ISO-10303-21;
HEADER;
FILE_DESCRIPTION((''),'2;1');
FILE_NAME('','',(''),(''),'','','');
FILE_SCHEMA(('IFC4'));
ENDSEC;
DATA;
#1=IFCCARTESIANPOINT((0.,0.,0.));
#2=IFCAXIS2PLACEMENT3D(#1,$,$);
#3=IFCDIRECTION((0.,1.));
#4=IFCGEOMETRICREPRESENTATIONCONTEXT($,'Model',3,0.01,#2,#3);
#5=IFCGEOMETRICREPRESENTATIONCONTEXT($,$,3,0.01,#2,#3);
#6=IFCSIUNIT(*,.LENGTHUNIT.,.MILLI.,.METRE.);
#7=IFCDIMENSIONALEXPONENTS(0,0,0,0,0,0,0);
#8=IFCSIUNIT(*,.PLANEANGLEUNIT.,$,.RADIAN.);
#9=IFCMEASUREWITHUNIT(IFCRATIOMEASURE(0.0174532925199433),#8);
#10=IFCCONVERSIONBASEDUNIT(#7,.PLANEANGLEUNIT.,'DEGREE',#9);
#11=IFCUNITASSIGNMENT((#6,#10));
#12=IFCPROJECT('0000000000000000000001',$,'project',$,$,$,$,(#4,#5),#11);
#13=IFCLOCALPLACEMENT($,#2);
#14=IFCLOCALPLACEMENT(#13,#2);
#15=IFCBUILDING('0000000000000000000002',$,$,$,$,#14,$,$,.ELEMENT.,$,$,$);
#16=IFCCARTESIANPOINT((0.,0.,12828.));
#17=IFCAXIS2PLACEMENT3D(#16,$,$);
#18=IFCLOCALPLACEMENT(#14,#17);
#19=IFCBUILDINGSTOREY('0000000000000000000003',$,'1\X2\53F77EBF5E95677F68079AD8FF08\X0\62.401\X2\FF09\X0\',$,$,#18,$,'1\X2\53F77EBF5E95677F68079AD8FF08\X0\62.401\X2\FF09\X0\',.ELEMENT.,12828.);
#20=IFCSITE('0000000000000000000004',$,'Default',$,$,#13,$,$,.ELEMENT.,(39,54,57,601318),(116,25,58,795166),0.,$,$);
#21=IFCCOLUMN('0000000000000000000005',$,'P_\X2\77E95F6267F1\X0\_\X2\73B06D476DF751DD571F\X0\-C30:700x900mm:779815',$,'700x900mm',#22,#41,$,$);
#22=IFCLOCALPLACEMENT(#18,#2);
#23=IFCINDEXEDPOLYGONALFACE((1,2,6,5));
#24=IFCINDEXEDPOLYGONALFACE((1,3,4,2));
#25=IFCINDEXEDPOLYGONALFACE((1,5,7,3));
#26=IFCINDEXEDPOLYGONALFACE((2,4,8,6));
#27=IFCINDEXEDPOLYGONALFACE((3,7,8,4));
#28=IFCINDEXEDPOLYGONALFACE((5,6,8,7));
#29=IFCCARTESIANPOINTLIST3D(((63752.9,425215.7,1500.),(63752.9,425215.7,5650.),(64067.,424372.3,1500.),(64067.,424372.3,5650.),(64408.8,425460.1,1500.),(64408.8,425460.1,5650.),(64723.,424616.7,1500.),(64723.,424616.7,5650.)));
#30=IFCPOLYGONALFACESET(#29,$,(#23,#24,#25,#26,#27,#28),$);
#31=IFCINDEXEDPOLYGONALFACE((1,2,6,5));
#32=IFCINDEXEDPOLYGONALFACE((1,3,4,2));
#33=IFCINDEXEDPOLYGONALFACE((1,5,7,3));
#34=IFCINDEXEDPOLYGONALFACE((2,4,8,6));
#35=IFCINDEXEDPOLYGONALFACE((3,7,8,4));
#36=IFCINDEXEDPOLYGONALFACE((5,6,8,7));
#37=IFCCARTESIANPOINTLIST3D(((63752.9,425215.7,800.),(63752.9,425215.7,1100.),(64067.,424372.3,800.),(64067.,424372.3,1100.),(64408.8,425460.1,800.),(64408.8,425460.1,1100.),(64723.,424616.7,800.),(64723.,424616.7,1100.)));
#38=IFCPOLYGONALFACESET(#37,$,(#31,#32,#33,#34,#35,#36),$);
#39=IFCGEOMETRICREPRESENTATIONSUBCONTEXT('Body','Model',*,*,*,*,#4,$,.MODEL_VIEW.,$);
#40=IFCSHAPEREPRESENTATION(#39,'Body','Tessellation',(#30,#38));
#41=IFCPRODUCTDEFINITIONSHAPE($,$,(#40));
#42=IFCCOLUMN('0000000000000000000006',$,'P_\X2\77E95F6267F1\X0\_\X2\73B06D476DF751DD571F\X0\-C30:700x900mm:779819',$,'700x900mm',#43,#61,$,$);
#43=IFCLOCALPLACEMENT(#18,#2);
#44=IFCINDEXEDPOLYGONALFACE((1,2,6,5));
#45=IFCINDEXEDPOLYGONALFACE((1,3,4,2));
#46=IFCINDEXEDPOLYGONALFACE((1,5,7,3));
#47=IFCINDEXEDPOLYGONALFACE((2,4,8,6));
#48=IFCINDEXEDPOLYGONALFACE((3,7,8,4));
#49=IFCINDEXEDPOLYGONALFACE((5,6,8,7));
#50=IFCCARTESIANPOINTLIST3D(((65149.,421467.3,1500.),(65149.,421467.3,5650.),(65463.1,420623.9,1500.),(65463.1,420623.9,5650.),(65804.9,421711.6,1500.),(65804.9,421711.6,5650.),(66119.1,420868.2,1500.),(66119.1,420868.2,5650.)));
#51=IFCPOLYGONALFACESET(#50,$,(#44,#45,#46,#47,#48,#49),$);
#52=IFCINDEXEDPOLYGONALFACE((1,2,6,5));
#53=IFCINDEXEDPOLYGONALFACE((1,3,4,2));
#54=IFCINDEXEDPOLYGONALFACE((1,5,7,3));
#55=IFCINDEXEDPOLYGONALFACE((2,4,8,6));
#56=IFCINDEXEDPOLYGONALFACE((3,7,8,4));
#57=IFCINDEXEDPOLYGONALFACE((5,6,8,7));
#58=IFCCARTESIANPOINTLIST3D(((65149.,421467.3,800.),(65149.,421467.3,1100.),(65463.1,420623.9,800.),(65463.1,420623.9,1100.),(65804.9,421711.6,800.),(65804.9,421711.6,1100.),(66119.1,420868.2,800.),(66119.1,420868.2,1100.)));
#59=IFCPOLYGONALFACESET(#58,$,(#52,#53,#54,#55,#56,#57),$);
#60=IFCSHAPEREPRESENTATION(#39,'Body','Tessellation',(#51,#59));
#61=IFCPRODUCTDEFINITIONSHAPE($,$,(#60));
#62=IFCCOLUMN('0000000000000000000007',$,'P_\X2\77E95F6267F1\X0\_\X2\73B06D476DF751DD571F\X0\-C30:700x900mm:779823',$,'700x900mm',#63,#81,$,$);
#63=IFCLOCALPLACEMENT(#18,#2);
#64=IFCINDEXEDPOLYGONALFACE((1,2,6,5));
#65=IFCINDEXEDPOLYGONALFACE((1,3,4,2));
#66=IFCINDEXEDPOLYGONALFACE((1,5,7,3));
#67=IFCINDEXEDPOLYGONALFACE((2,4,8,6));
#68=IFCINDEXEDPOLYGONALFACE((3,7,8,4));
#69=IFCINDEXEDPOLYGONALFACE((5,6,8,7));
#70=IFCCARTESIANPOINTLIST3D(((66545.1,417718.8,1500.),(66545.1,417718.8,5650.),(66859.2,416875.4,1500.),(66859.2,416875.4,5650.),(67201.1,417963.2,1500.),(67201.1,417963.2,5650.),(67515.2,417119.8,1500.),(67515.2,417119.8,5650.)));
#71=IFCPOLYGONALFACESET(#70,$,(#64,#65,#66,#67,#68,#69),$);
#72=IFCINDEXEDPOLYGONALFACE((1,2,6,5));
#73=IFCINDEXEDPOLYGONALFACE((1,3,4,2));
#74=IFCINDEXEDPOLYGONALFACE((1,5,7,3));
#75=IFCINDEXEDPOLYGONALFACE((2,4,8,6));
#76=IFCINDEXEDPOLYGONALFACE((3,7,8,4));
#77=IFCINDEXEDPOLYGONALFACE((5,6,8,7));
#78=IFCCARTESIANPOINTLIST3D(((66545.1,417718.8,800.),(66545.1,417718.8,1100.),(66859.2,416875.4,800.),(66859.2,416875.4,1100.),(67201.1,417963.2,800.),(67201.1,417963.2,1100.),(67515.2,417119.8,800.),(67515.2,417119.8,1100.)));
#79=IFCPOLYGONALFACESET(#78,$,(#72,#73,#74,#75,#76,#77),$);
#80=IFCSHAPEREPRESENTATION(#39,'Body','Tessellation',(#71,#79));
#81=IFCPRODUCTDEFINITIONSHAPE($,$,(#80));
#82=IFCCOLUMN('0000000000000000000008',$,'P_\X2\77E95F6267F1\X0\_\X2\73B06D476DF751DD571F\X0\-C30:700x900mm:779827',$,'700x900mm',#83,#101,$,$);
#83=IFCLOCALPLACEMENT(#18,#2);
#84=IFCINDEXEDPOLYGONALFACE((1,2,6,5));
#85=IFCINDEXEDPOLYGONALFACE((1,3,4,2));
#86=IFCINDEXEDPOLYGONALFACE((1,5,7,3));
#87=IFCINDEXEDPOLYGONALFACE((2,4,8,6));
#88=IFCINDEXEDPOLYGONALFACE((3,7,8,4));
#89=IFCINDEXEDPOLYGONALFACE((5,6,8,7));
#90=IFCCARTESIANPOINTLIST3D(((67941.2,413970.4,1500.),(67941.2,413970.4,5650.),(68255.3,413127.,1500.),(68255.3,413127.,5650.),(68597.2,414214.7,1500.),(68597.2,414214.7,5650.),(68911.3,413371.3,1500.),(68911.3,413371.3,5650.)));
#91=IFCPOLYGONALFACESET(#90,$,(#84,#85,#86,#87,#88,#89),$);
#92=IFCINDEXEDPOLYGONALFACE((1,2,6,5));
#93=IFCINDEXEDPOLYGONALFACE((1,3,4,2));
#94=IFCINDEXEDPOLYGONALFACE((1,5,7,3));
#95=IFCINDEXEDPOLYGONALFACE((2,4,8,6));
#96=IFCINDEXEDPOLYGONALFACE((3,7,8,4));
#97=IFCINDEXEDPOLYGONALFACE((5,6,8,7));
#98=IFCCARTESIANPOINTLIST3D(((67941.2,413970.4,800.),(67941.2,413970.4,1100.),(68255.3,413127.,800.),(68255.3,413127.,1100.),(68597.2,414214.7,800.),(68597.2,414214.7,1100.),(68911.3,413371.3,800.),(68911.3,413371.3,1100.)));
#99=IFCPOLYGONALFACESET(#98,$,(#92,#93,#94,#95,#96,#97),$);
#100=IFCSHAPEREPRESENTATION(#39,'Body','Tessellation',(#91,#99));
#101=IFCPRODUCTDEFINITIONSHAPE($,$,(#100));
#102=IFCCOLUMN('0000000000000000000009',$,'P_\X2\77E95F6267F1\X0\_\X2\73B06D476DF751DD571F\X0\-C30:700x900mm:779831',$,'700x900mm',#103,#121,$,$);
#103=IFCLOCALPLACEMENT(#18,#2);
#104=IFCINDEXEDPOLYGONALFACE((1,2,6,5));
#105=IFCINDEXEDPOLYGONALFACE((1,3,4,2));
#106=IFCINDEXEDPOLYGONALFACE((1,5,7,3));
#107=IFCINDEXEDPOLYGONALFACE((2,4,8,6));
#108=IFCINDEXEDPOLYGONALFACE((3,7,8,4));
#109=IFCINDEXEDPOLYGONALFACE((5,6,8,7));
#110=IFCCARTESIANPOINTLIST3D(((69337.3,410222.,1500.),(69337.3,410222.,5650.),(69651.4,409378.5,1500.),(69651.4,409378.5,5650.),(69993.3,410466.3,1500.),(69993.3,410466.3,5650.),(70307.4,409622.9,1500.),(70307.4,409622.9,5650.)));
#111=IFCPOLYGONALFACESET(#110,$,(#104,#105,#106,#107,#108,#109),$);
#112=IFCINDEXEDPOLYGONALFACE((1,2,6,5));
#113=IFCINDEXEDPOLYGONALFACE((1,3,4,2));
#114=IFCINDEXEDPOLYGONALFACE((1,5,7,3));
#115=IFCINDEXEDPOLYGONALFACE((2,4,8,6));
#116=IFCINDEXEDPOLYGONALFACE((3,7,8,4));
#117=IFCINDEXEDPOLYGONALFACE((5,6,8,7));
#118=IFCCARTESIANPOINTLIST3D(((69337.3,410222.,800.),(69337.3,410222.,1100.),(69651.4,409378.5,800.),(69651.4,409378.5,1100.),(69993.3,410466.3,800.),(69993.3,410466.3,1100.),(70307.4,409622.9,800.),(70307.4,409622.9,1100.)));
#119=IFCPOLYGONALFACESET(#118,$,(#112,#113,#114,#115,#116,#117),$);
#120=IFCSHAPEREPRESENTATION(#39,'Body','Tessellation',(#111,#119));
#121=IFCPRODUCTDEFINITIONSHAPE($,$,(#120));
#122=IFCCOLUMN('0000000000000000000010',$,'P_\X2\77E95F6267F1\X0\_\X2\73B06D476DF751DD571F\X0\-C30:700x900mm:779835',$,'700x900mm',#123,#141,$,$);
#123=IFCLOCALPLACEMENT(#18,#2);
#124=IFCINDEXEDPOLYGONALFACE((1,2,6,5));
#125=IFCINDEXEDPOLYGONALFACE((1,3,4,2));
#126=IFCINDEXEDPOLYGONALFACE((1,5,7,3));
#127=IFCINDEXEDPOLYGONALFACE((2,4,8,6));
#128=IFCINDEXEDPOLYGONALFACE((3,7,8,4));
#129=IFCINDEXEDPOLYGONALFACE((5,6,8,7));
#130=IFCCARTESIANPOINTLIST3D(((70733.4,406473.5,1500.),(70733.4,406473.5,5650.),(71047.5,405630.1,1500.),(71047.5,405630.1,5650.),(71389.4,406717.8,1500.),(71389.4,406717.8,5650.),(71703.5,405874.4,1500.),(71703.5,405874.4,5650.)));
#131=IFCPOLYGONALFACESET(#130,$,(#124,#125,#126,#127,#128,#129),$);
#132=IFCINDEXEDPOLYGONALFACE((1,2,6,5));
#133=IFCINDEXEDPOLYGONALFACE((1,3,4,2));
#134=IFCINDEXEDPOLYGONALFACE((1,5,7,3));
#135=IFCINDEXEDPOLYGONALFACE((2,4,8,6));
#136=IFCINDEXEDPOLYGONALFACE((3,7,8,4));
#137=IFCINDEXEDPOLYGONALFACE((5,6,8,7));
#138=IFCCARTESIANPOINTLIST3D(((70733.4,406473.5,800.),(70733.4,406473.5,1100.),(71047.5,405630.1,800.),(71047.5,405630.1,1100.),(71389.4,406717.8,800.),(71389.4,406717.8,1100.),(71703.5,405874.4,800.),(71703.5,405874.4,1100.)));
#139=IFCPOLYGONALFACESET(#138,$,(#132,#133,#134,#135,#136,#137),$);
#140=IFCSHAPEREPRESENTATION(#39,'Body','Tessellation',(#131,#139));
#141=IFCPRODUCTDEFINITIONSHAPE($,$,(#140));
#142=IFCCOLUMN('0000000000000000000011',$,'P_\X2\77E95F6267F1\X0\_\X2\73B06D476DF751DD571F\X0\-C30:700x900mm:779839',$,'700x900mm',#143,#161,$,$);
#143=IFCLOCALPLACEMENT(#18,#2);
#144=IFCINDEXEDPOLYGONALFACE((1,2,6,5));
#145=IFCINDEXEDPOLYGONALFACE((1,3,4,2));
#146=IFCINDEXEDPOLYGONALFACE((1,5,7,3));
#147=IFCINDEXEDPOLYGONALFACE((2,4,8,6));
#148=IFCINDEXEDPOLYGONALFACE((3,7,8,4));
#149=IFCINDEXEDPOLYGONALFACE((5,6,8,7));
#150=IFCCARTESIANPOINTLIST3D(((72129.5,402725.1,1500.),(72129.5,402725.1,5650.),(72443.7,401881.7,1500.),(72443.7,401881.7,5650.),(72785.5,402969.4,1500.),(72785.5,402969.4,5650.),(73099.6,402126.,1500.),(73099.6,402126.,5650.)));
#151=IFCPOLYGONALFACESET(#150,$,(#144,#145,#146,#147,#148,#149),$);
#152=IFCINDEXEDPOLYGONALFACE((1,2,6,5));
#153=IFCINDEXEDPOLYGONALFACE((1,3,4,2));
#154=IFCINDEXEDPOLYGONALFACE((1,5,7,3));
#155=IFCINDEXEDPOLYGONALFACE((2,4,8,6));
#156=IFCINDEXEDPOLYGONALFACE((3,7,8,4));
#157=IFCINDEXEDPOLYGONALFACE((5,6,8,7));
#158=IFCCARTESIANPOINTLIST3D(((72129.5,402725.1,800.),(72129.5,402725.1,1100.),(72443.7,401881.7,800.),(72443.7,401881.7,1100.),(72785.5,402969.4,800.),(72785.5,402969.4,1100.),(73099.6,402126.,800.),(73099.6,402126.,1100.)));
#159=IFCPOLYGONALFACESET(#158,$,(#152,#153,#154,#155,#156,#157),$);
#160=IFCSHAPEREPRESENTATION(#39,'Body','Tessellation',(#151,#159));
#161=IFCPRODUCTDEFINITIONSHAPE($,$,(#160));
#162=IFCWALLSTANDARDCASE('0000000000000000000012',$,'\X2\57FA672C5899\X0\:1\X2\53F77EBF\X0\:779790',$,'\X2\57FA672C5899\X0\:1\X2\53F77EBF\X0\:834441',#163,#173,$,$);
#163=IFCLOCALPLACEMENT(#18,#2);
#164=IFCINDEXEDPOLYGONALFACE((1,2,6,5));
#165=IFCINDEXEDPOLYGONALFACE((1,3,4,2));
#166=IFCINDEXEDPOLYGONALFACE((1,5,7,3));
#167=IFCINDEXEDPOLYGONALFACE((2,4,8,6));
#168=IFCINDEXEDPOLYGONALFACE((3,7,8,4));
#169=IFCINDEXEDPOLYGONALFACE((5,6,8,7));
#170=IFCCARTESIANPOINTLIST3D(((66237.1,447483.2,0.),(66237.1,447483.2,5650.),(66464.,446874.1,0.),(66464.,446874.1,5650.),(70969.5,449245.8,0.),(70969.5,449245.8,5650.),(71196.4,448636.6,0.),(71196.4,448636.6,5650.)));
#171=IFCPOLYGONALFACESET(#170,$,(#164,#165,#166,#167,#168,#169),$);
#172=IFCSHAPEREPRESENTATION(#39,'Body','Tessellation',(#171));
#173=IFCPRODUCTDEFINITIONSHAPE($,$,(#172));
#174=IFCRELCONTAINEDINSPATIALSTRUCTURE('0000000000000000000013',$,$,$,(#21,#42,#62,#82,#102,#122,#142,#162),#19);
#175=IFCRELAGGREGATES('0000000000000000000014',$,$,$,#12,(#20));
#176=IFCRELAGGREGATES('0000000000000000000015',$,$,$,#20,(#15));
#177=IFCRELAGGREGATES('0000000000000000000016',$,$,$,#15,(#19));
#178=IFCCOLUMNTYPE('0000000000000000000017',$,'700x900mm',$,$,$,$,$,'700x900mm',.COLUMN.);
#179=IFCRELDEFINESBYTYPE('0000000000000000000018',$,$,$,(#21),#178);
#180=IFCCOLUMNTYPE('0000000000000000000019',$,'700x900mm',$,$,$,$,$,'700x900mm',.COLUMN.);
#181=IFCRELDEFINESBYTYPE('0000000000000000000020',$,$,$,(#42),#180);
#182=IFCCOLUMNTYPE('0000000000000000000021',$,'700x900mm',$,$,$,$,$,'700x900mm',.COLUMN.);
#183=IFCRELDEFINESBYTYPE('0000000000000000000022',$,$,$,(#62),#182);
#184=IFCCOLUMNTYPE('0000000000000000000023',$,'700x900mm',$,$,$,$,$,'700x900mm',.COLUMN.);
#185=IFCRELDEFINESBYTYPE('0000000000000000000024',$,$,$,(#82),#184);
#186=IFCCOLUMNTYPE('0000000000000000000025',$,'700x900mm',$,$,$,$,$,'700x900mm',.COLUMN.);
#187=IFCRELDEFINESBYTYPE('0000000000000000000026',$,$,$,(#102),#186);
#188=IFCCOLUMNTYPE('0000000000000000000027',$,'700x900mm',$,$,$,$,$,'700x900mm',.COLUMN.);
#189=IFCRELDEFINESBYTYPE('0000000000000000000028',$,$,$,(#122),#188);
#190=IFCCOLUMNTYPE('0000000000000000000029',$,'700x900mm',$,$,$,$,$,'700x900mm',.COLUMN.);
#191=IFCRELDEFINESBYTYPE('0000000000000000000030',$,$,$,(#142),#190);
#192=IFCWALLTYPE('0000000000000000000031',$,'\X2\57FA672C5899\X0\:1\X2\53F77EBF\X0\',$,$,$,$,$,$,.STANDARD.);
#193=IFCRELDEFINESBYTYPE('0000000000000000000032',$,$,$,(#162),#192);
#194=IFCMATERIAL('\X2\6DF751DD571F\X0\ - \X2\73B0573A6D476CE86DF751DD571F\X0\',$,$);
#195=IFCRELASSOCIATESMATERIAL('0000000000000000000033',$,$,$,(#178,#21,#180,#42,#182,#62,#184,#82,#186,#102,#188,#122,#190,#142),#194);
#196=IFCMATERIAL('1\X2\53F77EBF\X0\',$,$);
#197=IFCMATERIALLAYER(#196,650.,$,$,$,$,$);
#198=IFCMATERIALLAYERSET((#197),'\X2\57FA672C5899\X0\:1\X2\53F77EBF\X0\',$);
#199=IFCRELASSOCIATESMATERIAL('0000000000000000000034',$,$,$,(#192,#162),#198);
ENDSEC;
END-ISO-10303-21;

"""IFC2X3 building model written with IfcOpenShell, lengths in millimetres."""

from ifc_helpers import new_model, entity, si_unit, converted_unit, direction, frame, frame_2d, origin, place, context, subcontext, project, spatial, polyline, rectangle, extrude, clip, bounded_halfspace, source, transform, mapped, material, layer, layer_set, layer_usage, type_object, type_shapes, element, save


model = new_model("IFC2X3")

# Units and contexts
model_context = context("Model", 3, precision=0.01, world=origin(), true_north=direction((0.0, 1.0)))
context_of_model = context(None, 3, precision=0.01, world=origin(), true_north=direction((0.0, 1.0)))
body_context = subcontext(model_context, "Body", "Model", "MODEL_VIEW")
ifc_project = project(units=[si_unit("LENGTHUNIT", "METRE", prefix="MILLI"), converted_unit("PLANEANGLEUNIT", "DEGREE", entity("IfcRatioMeasure", 0.0174532925199433), si_unit("PLANEANGLEUNIT", "RADIAN"), dimensions=[0, 0, 0, 0, 0, 0, 0])], contexts=[model_context, context_of_model])

# Site, building, storey
site_placement = place(None, origin())
site = spatial("IfcSite", under=ifc_project, at=site_placement, Name="Default", CompositionType="ELEMENT", RefLatitude=(39, 54, 57, 601318), RefLongitude=(116, 25, 58, 795166), RefElevation=0.0)
building_placement = place(site_placement, origin())
building = spatial("IfcBuilding", under=site, at=building_placement, CompositionType="ELEMENT")
storey_placement = place(building_placement, frame((0.0, 0.0, 12828.0)))
storey = spatial("IfcBuildingStorey", under=building, at=storey_placement, Name="1号线底板标高（62.401）", LongName="1号线底板标高（62.401）", CompositionType="ELEMENT", Elevation=12828.0)

# Columns
ifc_material_1 = material(Name="混凝土 - 现场浇注混凝土")
column_type_1 = type_object("IfcColumnType", Name="700x900mm", ElementType="700x900mm", PredefinedType="COLUMN", material=ifc_material_1)
shared_shape_1 = source(origin(), body_context, "Body", "SweptSolid", [
    extrude(rectangle(XDim=700.0, YDim=900.0, at=frame_2d((0.0, 0.0), x_axis=(1.0, 0.0))), frame((485.1, 543.9, 700.0), z_axis=(0.0, 0.0, 1.0), x_axis=(-0.937112, -0.349028, 0.0)), (0.0, 0.0, 1.0), 4150.0),
    extrude(rectangle(XDim=700.0, YDim=900.0, at=frame_2d((0.0, 0.0), x_axis=(1.0, 0.0))), frame((485.1, 543.9, 0.0), z_axis=(0.0, 0.0, 1.0), x_axis=(-0.937112, -0.349028, 0.0)), (0.0, 0.0, 1.0), 300.0),
])
type_shapes(column_type_1, [shared_shape_1])
column_1_placement = place(storey_placement, frame((63752.9, 424372.3, 800.0)))
element("IfcColumn", 1, at=column_1_placement, inside=storey, type_object=column_type_1, material=ifc_material_1, Name="P_矩形柱_现浇混凝土-C30:700x900mm:779815", ObjectType="700x900mm", context=body_context, shape_type="MappedRepresentation", body=[
    mapped(shared_shape_1, transform((0.0, 0.0, 0.0), scale=1.0)),
])
column_type_2 = type_object("IfcColumnType", Name="700x900mm", ElementType="700x900mm", PredefinedType="COLUMN", material=ifc_material_1)
shared_shape_2 = source(origin(), body_context, "Body", "SweptSolid", [
    extrude(rectangle(XDim=700.0, YDim=900.0, at=frame_2d((0.0, 0.0), x_axis=(1.0, 0.0))), frame((485.1, 543.9, 700.0), z_axis=(0.0, 0.0, 1.0), x_axis=(-0.937112, -0.349028, 0.0)), (0.0, 0.0, 1.0), 4150.0),
    extrude(rectangle(XDim=700.0, YDim=900.0, at=frame_2d((0.0, 0.0), x_axis=(1.0, 0.0))), frame((485.1, 543.9, 0.0), z_axis=(0.0, 0.0, 1.0), x_axis=(-0.937112, -0.349028, 0.0)), (0.0, 0.0, 1.0), 300.0),
])
type_shapes(column_type_2, [shared_shape_2])
column_2_placement = place(storey_placement, frame((65149.0, 420623.9, 800.0)))
element("IfcColumn", 2, at=column_2_placement, inside=storey, type_object=column_type_2, material=ifc_material_1, Name="P_矩形柱_现浇混凝土-C30:700x900mm:779819", ObjectType="700x900mm", context=body_context, shape_type="MappedRepresentation", body=[
    mapped(shared_shape_2, transform((0.0, 0.0, 0.0), scale=1.0)),
])
column_type_3 = type_object("IfcColumnType", Name="700x900mm", ElementType="700x900mm", PredefinedType="COLUMN", material=ifc_material_1)
shared_shape_3 = source(origin(), body_context, "Body", "SweptSolid", [
    extrude(rectangle(XDim=700.0, YDim=900.0, at=frame_2d((0.0, 0.0), x_axis=(1.0, 0.0))), frame((485.1, 543.9, 700.0), z_axis=(0.0, 0.0, 1.0), x_axis=(-0.937112, -0.349028, 0.0)), (0.0, 0.0, 1.0), 4150.0),
    extrude(rectangle(XDim=700.0, YDim=900.0, at=frame_2d((0.0, 0.0), x_axis=(1.0, 0.0))), frame((485.1, 543.9, 0.0), z_axis=(0.0, 0.0, 1.0), x_axis=(-0.937112, -0.349028, 0.0)), (0.0, 0.0, 1.0), 300.0),
])
type_shapes(column_type_3, [shared_shape_3])
column_3_placement = place(storey_placement, frame((66545.1, 416875.4, 800.0)))
element("IfcColumn", 3, at=column_3_placement, inside=storey, type_object=column_type_3, material=ifc_material_1, Name="P_矩形柱_现浇混凝土-C30:700x900mm:779823", ObjectType="700x900mm", context=body_context, shape_type="MappedRepresentation", body=[
    mapped(shared_shape_3, transform((0.0, 0.0, 0.0), scale=1.0)),
])
column_type_4 = type_object("IfcColumnType", Name="700x900mm", ElementType="700x900mm", PredefinedType="COLUMN", material=ifc_material_1)
shared_shape_4 = source(origin(), body_context, "Body", "SweptSolid", [
    extrude(rectangle(XDim=700.0, YDim=900.0, at=frame_2d((0.0, 0.0), x_axis=(1.0, 0.0))), frame((485.1, 543.9, 700.0), z_axis=(0.0, 0.0, 1.0), x_axis=(-0.937112, -0.349028, 0.0)), (0.0, 0.0, 1.0), 4150.0),
    extrude(rectangle(XDim=700.0, YDim=900.0, at=frame_2d((0.0, 0.0), x_axis=(1.0, 0.0))), frame((485.1, 543.9, 0.0), z_axis=(0.0, 0.0, 1.0), x_axis=(-0.937112, -0.349028, 0.0)), (0.0, 0.0, 1.0), 300.0),
])
type_shapes(column_type_4, [shared_shape_4])
column_4_placement = place(storey_placement, frame((67941.2, 413127.0, 800.0)))
element("IfcColumn", 4, at=column_4_placement, inside=storey, type_object=column_type_4, material=ifc_material_1, Name="P_矩形柱_现浇混凝土-C30:700x900mm:779827", ObjectType="700x900mm", context=body_context, shape_type="MappedRepresentation", body=[
    mapped(shared_shape_4, transform((0.0, 0.0, 0.0), scale=1.0)),
])
column_type_5 = type_object("IfcColumnType", Name="700x900mm", ElementType="700x900mm", PredefinedType="COLUMN", material=ifc_material_1)
shared_shape_5 = source(origin(), body_context, "Body", "SweptSolid", [
    extrude(rectangle(XDim=700.0, YDim=900.0, at=frame_2d((0.0, 0.0), x_axis=(1.0, 0.0))), frame((485.1, 543.9, 700.0), z_axis=(0.0, 0.0, 1.0), x_axis=(-0.937112, -0.349028, 0.0)), (0.0, 0.0, 1.0), 4150.0),
    extrude(rectangle(XDim=700.0, YDim=900.0, at=frame_2d((0.0, 0.0), x_axis=(1.0, 0.0))), frame((485.1, 543.9, 0.0), z_axis=(0.0, 0.0, 1.0), x_axis=(-0.937112, -0.349028, 0.0)), (0.0, 0.0, 1.0), 300.0),
])
type_shapes(column_type_5, [shared_shape_5])
column_5_placement = place(storey_placement, frame((69337.3, 409378.5, 800.0)))
element("IfcColumn", 5, at=column_5_placement, inside=storey, type_object=column_type_5, material=ifc_material_1, Name="P_矩形柱_现浇混凝土-C30:700x900mm:779831", ObjectType="700x900mm", context=body_context, shape_type="MappedRepresentation", body=[
    mapped(shared_shape_5, transform((0.0, 0.0, 0.0), scale=1.0)),
])
column_type_6 = type_object("IfcColumnType", Name="700x900mm", ElementType="700x900mm", PredefinedType="COLUMN", material=ifc_material_1)
shared_shape_6 = source(origin(), body_context, "Body", "SweptSolid", [
    extrude(rectangle(XDim=700.0, YDim=900.0, at=frame_2d((0.0, 0.0), x_axis=(1.0, 0.0))), frame((485.1, 543.9, 700.0), z_axis=(0.0, 0.0, 1.0), x_axis=(-0.937112, -0.349028, 0.0)), (0.0, 0.0, 1.0), 4150.0),
    extrude(rectangle(XDim=700.0, YDim=900.0, at=frame_2d((0.0, 0.0), x_axis=(1.0, 0.0))), frame((485.1, 543.9, 0.0), z_axis=(0.0, 0.0, 1.0), x_axis=(-0.937112, -0.349028, 0.0)), (0.0, 0.0, 1.0), 300.0),
])
type_shapes(column_type_6, [shared_shape_6])
column_6_placement = place(storey_placement, frame((70733.4, 405630.1, 800.0)))
element("IfcColumn", 6, at=column_6_placement, inside=storey, type_object=column_type_6, material=ifc_material_1, Name="P_矩形柱_现浇混凝土-C30:700x900mm:779835", ObjectType="700x900mm", context=body_context, shape_type="MappedRepresentation", body=[
    mapped(shared_shape_6, transform((0.0, 0.0, 0.0), scale=1.0)),
])
column_type_7 = type_object("IfcColumnType", Name="700x900mm", ElementType="700x900mm", PredefinedType="COLUMN", material=ifc_material_1)
shared_shape_7 = source(origin(), body_context, "Body", "SweptSolid", [
    extrude(rectangle(XDim=700.0, YDim=900.0, at=frame_2d((0.0, 0.0), x_axis=(1.0, 0.0))), frame((485.1, 543.9, 700.0), z_axis=(0.0, 0.0, 1.0), x_axis=(-0.937112, -0.349028, 0.0)), (0.0, 0.0, 1.0), 4150.0),
    extrude(rectangle(XDim=700.0, YDim=900.0, at=frame_2d((0.0, 0.0), x_axis=(1.0, 0.0))), frame((485.1, 543.9, 0.0), z_axis=(0.0, 0.0, 1.0), x_axis=(-0.937112, -0.349028, 0.0)), (0.0, 0.0, 1.0), 300.0),
])
type_shapes(column_type_7, [shared_shape_7])
column_7_placement = place(storey_placement, frame((72129.5, 401881.7, 800.0)))
element("IfcColumn", 7, at=column_7_placement, inside=storey, type_object=column_type_7, material=ifc_material_1, Name="P_矩形柱_现浇混凝土-C30:700x900mm:779839", ObjectType="700x900mm", context=body_context, shape_type="MappedRepresentation", body=[
    mapped(shared_shape_7, transform((0.0, 0.0, 0.0), scale=1.0)),
])

# Wall
ifc_material_2 = material(Name="1号线")
ifc_layer_1 = layer(ifc_material_2, 650.0)
ifc_layer_set_1 = layer_set([ifc_layer_1], Name="基本墙:1号线")
ifc_layer_usage_1 = layer_usage(ifc_layer_set_1, "AXIS2", "NEGATIVE", 325.0)
wall_type = type_object("IfcWallType", Name="基本墙:1号线", PredefinedType="STANDARD", material=ifc_layer_set_1)
wall_1_placement = place(storey_placement, frame((71083.0, 448941.2, 0.0), z_axis=(0.0, 0.0, 1.0), x_axis=(-0.937112, -0.349028, 0.0)))
element("IfcWallStandardCase", 8, at=wall_1_placement, inside=storey, type_object=wall_type, material=ifc_layer_usage_1, Name="基本墙:1号线:779790", ObjectType="基本墙:1号线:834441", context=body_context, shape_type="Clipping", body=[
    clip(extrude(rectangle(XDim=5050.0, YDim=650.0, at=frame_2d((2525.0, 0.0), x_axis=(-1.0, 0.0))), origin(), (0.0, 0.0, 1.0), 5650.0), bounded_halfspace(frame((0.0, -325.0, 5650.0), z_axis=(0.0, 0.0, -1.0), x_axis=(-1.0, 0.0, 0.0)), True, frame((0.0, -325.0, 5650.0)), polyline([(0.0, 0.0), (3349.5, 0.0), (5050.0, 0.0), (5050.0, 650.0), (4400.0, 650.0), (650.0, 650.0), (0.0, 650.0), (0.0, 0.0)]))),
])

save(model, "model.ifc")
